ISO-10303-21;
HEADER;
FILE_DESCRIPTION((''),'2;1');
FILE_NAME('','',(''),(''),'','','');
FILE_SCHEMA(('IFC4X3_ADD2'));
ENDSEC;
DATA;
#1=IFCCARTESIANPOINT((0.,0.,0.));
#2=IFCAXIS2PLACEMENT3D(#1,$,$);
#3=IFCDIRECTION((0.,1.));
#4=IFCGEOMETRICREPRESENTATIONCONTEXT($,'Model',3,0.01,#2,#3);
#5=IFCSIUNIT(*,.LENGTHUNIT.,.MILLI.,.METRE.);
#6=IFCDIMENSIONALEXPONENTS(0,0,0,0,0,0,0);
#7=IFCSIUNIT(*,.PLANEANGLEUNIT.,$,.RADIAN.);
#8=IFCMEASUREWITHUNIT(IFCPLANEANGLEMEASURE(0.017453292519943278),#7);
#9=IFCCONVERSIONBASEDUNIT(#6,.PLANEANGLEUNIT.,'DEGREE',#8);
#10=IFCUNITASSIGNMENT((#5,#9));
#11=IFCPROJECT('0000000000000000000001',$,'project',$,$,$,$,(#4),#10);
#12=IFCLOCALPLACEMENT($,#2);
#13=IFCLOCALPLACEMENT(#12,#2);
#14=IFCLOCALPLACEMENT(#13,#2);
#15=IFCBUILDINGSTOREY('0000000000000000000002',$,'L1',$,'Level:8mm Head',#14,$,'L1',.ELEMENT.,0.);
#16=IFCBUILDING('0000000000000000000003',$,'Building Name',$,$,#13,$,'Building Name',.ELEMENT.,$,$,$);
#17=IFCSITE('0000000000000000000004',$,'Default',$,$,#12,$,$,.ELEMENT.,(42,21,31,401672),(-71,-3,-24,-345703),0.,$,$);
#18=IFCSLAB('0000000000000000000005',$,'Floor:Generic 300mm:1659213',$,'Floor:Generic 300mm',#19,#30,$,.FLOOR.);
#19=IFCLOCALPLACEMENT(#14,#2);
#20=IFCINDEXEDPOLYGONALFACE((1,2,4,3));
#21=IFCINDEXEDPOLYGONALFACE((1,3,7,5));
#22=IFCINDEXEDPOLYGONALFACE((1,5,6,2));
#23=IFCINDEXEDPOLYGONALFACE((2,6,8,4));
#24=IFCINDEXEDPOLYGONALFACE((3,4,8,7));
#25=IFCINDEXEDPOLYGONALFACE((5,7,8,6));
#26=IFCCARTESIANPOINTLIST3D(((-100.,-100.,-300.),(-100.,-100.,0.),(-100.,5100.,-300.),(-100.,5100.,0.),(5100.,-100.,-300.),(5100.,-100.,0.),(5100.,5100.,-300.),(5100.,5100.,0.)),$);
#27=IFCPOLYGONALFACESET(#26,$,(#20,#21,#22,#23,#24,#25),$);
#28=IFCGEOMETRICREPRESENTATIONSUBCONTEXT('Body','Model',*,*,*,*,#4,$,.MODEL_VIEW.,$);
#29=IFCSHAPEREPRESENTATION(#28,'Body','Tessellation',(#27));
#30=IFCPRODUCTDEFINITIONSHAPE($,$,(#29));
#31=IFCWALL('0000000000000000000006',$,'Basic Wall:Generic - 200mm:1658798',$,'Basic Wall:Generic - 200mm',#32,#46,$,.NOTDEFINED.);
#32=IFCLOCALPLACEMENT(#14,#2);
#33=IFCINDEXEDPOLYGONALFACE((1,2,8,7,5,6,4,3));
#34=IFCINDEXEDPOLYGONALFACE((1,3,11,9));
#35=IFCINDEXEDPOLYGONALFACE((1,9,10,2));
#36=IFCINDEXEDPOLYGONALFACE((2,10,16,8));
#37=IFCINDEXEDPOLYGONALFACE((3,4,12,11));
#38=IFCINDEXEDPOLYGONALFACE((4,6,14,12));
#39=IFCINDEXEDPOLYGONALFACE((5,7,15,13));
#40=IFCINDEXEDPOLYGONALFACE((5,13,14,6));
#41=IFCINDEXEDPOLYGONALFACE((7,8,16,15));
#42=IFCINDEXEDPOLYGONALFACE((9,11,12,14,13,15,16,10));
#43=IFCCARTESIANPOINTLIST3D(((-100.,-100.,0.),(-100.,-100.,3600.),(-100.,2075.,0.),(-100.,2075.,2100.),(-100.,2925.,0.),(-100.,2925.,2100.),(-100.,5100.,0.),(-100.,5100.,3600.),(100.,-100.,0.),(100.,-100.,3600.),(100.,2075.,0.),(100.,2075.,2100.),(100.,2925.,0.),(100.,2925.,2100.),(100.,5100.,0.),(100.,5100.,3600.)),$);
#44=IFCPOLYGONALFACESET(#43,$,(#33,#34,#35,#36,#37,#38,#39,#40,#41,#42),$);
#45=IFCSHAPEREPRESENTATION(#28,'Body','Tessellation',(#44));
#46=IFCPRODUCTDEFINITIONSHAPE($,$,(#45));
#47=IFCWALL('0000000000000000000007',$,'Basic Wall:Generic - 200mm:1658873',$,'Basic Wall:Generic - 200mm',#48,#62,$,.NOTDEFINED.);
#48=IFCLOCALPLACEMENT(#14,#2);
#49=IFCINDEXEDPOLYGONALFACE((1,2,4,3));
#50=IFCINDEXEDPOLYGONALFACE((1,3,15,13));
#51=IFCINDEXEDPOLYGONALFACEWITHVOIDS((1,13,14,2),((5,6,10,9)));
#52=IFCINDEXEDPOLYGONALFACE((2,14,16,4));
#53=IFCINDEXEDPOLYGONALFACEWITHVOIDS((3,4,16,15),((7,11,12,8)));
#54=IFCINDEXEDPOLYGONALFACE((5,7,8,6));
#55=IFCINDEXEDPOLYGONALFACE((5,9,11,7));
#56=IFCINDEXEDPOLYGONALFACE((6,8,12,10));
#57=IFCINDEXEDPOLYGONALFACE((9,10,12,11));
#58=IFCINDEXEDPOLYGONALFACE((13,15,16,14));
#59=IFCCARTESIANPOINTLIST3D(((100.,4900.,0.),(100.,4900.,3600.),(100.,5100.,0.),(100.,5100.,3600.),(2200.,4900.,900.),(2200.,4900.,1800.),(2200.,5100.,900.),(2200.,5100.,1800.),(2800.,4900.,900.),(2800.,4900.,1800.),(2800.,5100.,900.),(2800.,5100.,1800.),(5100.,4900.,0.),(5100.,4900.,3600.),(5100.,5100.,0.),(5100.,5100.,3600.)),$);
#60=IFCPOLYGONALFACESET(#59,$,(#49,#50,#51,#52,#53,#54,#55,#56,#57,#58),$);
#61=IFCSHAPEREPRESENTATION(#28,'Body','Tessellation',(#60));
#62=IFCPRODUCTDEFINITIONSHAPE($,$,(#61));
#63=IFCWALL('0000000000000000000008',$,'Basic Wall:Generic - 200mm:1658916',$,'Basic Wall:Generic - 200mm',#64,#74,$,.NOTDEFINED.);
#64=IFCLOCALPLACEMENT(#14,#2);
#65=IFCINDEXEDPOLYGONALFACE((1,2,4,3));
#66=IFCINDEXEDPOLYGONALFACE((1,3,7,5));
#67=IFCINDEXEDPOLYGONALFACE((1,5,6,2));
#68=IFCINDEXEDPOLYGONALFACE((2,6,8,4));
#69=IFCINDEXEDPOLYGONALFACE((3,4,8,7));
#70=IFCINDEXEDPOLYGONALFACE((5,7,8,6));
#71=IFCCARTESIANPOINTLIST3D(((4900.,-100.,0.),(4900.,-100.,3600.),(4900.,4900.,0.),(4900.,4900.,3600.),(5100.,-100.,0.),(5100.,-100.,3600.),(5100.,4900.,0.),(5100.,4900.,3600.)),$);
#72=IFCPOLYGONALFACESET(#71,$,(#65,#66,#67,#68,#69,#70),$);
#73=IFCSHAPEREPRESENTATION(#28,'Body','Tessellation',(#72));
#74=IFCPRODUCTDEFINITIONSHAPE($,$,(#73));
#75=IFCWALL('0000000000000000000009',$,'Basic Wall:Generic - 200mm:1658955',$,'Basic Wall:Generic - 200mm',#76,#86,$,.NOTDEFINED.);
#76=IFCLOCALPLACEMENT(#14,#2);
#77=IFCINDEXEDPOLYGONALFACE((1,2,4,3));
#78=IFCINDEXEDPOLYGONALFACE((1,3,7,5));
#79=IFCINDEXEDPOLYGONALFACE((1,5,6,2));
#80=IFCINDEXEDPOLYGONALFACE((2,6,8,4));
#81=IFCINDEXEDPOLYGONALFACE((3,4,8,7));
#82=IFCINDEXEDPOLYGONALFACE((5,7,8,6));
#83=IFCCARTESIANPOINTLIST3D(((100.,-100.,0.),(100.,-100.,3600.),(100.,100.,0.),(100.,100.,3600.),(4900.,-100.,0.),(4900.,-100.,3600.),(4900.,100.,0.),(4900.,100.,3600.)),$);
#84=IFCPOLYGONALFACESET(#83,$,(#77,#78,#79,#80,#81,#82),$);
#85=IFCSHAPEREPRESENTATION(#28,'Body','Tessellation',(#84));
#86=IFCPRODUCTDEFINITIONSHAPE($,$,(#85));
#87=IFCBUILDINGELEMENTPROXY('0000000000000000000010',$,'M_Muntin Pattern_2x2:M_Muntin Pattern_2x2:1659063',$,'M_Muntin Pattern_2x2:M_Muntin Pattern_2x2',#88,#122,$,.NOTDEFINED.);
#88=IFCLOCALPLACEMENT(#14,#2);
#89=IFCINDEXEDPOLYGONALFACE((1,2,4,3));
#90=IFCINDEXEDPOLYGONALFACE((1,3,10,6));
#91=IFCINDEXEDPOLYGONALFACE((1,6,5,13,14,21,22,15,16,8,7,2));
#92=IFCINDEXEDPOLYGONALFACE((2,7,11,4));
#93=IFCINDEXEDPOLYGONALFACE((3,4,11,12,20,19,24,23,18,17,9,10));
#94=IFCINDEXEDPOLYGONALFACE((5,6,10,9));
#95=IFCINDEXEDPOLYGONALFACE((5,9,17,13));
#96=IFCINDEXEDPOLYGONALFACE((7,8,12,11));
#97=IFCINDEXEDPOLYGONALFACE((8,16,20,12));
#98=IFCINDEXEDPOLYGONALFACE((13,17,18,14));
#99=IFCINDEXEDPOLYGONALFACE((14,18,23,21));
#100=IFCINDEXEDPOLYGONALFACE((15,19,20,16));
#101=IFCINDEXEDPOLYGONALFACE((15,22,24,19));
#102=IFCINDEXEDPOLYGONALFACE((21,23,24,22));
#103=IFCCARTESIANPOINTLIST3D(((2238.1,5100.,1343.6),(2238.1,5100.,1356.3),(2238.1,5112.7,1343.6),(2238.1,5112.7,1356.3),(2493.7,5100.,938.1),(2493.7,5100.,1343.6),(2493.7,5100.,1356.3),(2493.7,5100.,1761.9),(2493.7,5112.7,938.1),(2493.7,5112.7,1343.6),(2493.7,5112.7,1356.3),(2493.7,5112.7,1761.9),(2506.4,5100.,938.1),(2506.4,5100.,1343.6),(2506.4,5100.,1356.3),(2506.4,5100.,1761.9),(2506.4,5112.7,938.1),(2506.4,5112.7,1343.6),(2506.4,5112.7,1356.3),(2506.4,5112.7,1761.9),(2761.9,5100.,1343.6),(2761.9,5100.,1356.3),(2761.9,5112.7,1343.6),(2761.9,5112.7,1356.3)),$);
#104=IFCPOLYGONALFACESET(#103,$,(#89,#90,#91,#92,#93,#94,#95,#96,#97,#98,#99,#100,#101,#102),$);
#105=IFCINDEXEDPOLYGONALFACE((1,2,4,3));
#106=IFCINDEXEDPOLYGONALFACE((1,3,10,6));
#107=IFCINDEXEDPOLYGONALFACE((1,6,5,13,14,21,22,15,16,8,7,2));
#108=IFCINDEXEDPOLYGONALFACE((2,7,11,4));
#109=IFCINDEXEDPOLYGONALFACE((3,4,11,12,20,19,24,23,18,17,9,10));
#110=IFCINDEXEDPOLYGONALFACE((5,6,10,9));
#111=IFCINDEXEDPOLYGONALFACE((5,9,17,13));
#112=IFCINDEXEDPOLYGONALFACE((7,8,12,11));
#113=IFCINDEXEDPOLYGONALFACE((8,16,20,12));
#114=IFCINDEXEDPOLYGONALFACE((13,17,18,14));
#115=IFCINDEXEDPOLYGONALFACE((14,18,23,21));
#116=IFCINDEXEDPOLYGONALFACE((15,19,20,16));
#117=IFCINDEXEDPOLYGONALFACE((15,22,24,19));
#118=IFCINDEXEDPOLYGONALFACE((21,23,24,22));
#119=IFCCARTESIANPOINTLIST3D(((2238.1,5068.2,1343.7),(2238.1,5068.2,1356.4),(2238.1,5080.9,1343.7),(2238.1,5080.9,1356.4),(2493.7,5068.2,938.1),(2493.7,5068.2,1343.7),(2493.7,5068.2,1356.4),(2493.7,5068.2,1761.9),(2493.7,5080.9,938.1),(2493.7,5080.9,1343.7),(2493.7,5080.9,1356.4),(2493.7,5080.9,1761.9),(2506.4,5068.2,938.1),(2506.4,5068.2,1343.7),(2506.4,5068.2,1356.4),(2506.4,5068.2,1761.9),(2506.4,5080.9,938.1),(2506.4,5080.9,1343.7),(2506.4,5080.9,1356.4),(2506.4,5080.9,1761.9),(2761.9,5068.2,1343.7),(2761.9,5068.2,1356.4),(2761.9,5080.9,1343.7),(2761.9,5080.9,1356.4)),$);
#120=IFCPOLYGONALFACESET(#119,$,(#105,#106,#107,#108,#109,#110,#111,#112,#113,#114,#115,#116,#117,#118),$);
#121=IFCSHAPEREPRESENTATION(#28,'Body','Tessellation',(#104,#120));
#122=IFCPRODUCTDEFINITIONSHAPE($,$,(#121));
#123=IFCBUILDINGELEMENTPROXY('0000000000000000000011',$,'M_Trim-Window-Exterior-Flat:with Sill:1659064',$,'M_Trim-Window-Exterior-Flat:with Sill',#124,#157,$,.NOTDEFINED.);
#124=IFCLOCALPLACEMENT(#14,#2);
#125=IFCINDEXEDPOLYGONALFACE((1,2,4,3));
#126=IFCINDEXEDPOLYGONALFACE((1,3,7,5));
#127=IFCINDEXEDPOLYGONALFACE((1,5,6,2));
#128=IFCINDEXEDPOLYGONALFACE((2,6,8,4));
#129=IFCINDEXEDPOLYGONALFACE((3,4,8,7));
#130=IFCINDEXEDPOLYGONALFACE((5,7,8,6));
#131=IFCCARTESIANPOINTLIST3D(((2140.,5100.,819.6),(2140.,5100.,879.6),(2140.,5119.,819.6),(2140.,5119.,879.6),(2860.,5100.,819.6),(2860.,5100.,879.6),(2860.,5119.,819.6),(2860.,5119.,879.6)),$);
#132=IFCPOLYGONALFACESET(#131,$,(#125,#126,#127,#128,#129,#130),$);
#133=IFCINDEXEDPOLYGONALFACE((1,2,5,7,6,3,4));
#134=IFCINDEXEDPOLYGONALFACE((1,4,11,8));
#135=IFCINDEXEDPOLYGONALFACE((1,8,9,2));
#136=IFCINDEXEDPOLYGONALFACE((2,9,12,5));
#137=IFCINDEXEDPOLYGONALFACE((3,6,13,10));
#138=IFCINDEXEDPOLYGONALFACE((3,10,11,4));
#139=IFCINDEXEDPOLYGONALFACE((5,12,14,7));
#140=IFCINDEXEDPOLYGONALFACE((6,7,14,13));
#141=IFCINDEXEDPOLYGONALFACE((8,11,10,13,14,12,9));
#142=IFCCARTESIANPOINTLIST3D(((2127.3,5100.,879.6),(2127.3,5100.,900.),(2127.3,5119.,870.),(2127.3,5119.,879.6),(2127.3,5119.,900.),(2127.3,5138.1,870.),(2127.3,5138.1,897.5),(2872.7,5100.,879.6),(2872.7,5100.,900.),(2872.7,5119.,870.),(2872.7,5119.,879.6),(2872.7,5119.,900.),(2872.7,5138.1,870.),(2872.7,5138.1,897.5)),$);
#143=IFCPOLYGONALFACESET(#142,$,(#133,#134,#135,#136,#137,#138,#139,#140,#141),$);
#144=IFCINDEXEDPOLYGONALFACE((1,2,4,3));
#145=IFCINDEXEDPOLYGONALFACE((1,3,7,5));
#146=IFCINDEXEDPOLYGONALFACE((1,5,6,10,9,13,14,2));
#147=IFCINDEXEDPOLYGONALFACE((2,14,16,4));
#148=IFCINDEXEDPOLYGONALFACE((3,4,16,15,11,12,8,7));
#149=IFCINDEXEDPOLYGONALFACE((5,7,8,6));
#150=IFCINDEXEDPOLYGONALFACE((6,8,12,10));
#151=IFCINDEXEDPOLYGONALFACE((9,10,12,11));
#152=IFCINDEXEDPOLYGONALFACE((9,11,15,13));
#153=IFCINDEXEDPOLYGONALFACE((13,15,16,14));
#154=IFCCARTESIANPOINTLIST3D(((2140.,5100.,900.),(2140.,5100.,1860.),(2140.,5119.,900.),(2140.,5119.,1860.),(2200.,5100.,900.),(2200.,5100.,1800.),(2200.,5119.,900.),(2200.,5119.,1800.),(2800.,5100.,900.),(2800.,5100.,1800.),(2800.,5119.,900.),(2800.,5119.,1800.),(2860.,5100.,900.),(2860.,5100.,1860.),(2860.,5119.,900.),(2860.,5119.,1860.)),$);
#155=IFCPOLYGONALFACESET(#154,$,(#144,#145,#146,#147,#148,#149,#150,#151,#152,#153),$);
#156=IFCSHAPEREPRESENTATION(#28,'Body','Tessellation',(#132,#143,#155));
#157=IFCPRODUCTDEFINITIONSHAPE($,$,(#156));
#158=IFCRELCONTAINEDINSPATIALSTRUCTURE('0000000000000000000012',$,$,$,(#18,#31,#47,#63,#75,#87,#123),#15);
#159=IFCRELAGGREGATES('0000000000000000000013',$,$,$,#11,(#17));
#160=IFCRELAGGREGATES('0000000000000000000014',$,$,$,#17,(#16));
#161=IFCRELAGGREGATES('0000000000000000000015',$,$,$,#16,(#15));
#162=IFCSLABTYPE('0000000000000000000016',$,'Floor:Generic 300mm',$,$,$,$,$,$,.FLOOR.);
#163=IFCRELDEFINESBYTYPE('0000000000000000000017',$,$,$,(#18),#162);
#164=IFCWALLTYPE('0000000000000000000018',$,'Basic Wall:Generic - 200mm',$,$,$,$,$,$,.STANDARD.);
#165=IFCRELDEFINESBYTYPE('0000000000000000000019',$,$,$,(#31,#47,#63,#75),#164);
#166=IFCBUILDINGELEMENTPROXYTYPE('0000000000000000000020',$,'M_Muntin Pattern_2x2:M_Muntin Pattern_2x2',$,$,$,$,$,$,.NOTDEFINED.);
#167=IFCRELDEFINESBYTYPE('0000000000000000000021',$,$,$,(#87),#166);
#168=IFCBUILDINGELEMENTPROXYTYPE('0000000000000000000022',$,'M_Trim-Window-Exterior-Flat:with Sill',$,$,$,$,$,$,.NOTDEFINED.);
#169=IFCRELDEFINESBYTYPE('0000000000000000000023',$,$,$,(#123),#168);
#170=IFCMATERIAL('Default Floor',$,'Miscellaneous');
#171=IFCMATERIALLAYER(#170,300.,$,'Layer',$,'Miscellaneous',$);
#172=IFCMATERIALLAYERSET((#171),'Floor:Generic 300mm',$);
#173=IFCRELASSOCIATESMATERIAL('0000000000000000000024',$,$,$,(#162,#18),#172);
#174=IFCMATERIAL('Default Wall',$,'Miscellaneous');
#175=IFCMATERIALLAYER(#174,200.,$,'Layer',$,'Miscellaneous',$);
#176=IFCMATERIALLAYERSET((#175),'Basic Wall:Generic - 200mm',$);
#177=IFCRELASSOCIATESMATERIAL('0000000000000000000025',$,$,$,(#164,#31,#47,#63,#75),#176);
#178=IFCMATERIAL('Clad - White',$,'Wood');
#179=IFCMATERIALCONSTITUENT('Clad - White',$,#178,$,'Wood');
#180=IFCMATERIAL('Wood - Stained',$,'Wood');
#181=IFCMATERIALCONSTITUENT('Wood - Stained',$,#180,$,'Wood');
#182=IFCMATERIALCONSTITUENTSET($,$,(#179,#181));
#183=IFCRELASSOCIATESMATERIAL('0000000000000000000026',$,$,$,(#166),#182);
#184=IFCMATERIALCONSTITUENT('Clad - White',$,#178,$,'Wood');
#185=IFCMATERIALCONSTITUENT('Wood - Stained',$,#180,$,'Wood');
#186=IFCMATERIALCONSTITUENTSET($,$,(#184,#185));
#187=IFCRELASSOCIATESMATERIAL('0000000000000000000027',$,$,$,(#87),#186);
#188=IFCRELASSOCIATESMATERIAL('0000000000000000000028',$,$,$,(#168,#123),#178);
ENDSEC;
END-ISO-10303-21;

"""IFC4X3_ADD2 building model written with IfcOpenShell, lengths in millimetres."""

from ifc_helpers import new_model, entity, si_unit, converted_unit, direction, frame, frame_2d, origin, place, context, subcontext, project, spatial, polyline, rectangle, outline, extrude, source, transform, mapped, material, layer, layer_set, layer_usage, constituent, constituent_set, type_object, type_shapes, element, save


model = new_model("IFC4X3_ADD2")

# Units and contexts
model_context = context("Model", 3, precision=0.01, world=origin(), true_north=direction((0.0, 1.0)))
body_context = subcontext(model_context, "Body", "Model", "MODEL_VIEW")
ifc_project = project(units=[si_unit("LENGTHUNIT", "METRE", prefix="MILLI"), converted_unit("PLANEANGLEUNIT", "DEGREE", entity("IfcPlaneAngleMeasure", 0.017453292519943278), si_unit("PLANEANGLEUNIT", "RADIAN"), dimensions=[0, 0, 0, 0, 0, 0, 0])], contexts=[model_context])

# Site, building, storey
site_placement = place(None, origin())
site = spatial("IfcSite", under=ifc_project, at=site_placement, Name="Default", CompositionType="ELEMENT", RefLatitude=(42, 21, 31, 401672), RefLongitude=(-71, -3, -24, -345703), RefElevation=0.0)
building_placement = place(site_placement, origin())
building = spatial("IfcBuilding", under=site, at=building_placement, Name="Building Name", LongName="Building Name", CompositionType="ELEMENT")
storey_placement = place(building_placement, origin())
storey = spatial("IfcBuildingStorey", under=building, at=storey_placement, Name="L1", ObjectType="Level:8mm Head", LongName="L1", CompositionType="ELEMENT", Elevation=0.0)

# Slab
ifc_material_1 = material(Name="Default Floor", Category="Miscellaneous")
ifc_layer_1 = layer(ifc_material_1, 300.0, Name="Layer", Category="Miscellaneous")
ifc_layer_set_1 = layer_set([ifc_layer_1], Name="Floor:Generic 300mm")
ifc_layer_usage = layer_usage(ifc_layer_set_1, "AXIS3", "POSITIVE", 0.0)
slab_type = type_object("IfcSlabType", Name="Floor:Generic 300mm", PredefinedType="FLOOR", material=ifc_layer_set_1)
slab_placement = place(storey_placement, origin())
element("IfcSlab", 1, at=slab_placement, inside=storey, type_object=slab_type, material=ifc_layer_usage, Name="Floor:Generic 300mm:1659213", ObjectType="Floor:Generic 300mm", PredefinedType="FLOOR", context=body_context, shape_type="SweptSolid", body=[
    extrude(rectangle(XDim=5200.0, YDim=5200.0, at=frame_2d((0.0, 0.0), x_axis=(1.0, 0.0))), frame((2500.0, 2500.0, 0.0), z_axis=(0.0, 0.0, -1.0), x_axis=(0.0, 1.0, 0.0)), (0.0, 0.0, 1.0), 300.0),
])

# Walls, openings
ifc_material_2 = material(Name="Default Wall", Category="Miscellaneous")
ifc_layer_2 = layer(ifc_material_2, 200.0, Name="Layer", Category="Miscellaneous")
ifc_layer_set_2 = layer_set([ifc_layer_2], Name="Basic Wall:Generic - 200mm")
wall_type = type_object("IfcWallType", Name="Basic Wall:Generic - 200mm", PredefinedType="STANDARD", material=ifc_layer_set_2)
wall_1_placement = place(storey_placement, frame((0.0, -100.0, 0.0), z_axis=(0.0, 0.0, 1.0), x_axis=(0.0, 1.0, 0.0)))
wall_1 = element("IfcWall", 2, at=wall_1_placement, inside=storey, type_object=wall_type, material=ifc_layer_set_2, Name="Basic Wall:Generic - 200mm:1658798", ObjectType="Basic Wall:Generic - 200mm", PredefinedType="NOTDEFINED", context=body_context, shape_type="SweptSolid", body=[
    extrude(rectangle(XDim=5200.0, YDim=200.0, at=frame_2d((2600.0, 0.0), x_axis=(1.0, 0.0))), origin(), (0.0, 0.0, 1.0), 3600.0),
])
opening_1_placement = place(wall_1_placement, frame((2175.0, -100.0, 0.0)))
element("IfcOpeningElement", 3, at=opening_1_placement, cuts=wall_1, PredefinedType="OPENING", context=body_context, shape_type="SweptSolid", body=[
    extrude(rectangle(XDim=2100.0, YDim=850.0, at=frame_2d((1050.0, 425.0), x_axis=(1.0, 0.0))), frame((0.0, 0.0, 0.0), z_axis=(0.0, 1.0, 0.0), x_axis=(0.0, 0.0, 1.0)), (0.0, 0.0, 1.0), 200.0),
])
wall_2_placement = place(storey_placement, frame((100.0, 5000.0, 0.0)))
wall_2 = element("IfcWall", 4, at=wall_2_placement, inside=storey, type_object=wall_type, material=ifc_layer_set_2, Name="Basic Wall:Generic - 200mm:1658873", ObjectType="Basic Wall:Generic - 200mm", PredefinedType="NOTDEFINED", context=body_context, shape_type="SweptSolid", body=[
    extrude(rectangle(XDim=5000.0, YDim=200.0, at=frame_2d((2500.0, 0.0), x_axis=(-1.0, 0.0))), origin(), (0.0, 0.0, 1.0), 3600.0),
])
opening_2_placement = place(wall_2_placement, frame((2100.0, -100.0, 900.0)))
element("IfcOpeningElement", 5, at=opening_2_placement, cuts=wall_2, PredefinedType="OPENING", context=body_context, shape_type="SweptSolid", body=[
    extrude(rectangle(XDim=900.0, YDim=600.0, at=frame_2d((450.0, 300.0), x_axis=(-1.0, 0.0))), frame((0.0, 0.0, 0.0), z_axis=(0.0, 1.0, 0.0), x_axis=(0.0, 0.0, 1.0)), (0.0, 0.0, 1.0), 200.0),
])

# Walls
wall_3_placement = place(storey_placement, frame((5000.0, 4900.0, 0.0), z_axis=(0.0, 0.0, 1.0), x_axis=(0.0, -1.0, 0.0)))
element("IfcWall", 6, at=wall_3_placement, inside=storey, type_object=wall_type, material=ifc_layer_set_2, Name="Basic Wall:Generic - 200mm:1658916", ObjectType="Basic Wall:Generic - 200mm", PredefinedType="NOTDEFINED", context=body_context, shape_type="SweptSolid", body=[
    extrude(rectangle(XDim=5000.0, YDim=200.0, at=frame_2d((2500.0, 0.0), x_axis=(-1.0, 0.0))), origin(), (0.0, 0.0, 1.0), 3600.0),
])
wall_4_placement = place(storey_placement, frame((4900.0, 0.0, 0.0), z_axis=(0.0, 0.0, 1.0), x_axis=(-1.0, 0.0, 0.0)))
element("IfcWall", 7, at=wall_4_placement, inside=storey, type_object=wall_type, material=ifc_layer_set_2, Name="Basic Wall:Generic - 200mm:1658955", ObjectType="Basic Wall:Generic - 200mm", PredefinedType="NOTDEFINED", context=body_context, shape_type="SweptSolid", body=[
    extrude(rectangle(XDim=4800.0, YDim=200.0, at=frame_2d((2400.0, 0.0), x_axis=(-1.0, 0.0))), origin(), (0.0, 0.0, 1.0), 3600.0),
])

# Building element proxies
ifc_material_3 = material(Name="Clad - White", Category="Wood")
ifc_constituent_1 = constituent(ifc_material_3, Name="Clad - White", Category="Wood")
ifc_material_4 = material(Name="Wood - Stained", Category="Wood")
ifc_constituent_2 = constituent(ifc_material_4, Name="Wood - Stained", Category="Wood")
ifc_constituent_set_1 = constituent_set(constituents=[ifc_constituent_1, ifc_constituent_2])
ifc_constituent_3 = constituent(ifc_material_3, Name="Clad - White", Category="Wood")
ifc_constituent_4 = constituent(ifc_material_4, Name="Wood - Stained", Category="Wood")
ifc_constituent_set_2 = constituent_set(constituents=[ifc_constituent_3, ifc_constituent_4])
building_element_proxy_type_1 = type_object("IfcBuildingElementProxyType", Name="M_Muntin Pattern_2x2:M_Muntin Pattern_2x2", PredefinedType="NOTDEFINED", material=ifc_constituent_set_2)
shared_shape_1 = source(origin(), body_context, "Body", "SweptSolid", [
    extrude(outline(polyline([(6.4, -6.4), (411.9, -6.4), (411.9, 6.3), (6.4, 6.3), (6.4, 261.9), (-6.3, 261.9), (-6.3, 6.3), (-411.9, 6.3), (-411.9, -6.4), (-6.3, -6.4), (-6.3, -261.9), (6.4, -261.9), (6.4, -6.4)])), frame((0.0, -22.2, 411.9), z_axis=(0.0, 1.0, 0.0), x_axis=(0.0, 0.0, 1.0)), (0.0, 0.0, 1.0), 12.7),
    extrude(outline(polyline([(6.4, -6.4), (411.9, -6.4), (411.9, 6.3), (6.4, 6.3), (6.4, 261.9), (-6.3, 261.9), (-6.3, 6.3), (-411.9, 6.3), (-411.9, -6.4), (-6.3, -6.4), (-6.3, -261.9), (6.4, -261.9), (6.4, -6.4)])), frame((0.0, 9.5, 411.9), z_axis=(0.0, 1.0, 0.0), x_axis=(0.0, 0.0, 1.0)), (0.0, 0.0, 1.0), 12.7),
])
type_shapes(building_element_proxy_type_1, [shared_shape_1])
proxy_1_placement = place(storey_placement, frame((2500.0, 5090.5, 938.1), z_axis=(0.0, 0.0, 1.0), x_axis=(-1.0, 0.0, 0.0)))
element("IfcBuildingElementProxy", 8, at=proxy_1_placement, inside=storey, type_object=building_element_proxy_type_1, material=ifc_constituent_set_1, Name="M_Muntin Pattern_2x2:M_Muntin Pattern_2x2:1659063", ObjectType="M_Muntin Pattern_2x2:M_Muntin Pattern_2x2", PredefinedType="NOTDEFINED", context=body_context, shape_type="MappedRepresentation", body=[
    mapped(shared_shape_1, transform((0.0, 0.0, 0.0), scale=1.0)),
])
building_element_proxy_type_2 = type_object("IfcBuildingElementProxyType", Name="M_Trim-Window-Exterior-Flat:with Sill", PredefinedType="NOTDEFINED", material=ifc_material_3)
shared_shape_2 = source(origin(), body_context, "Body", "SweptSolid", [
    extrude(rectangle(XDim=720.0, YDim=60.0, at=frame_2d((0.0, 0.0), x_axis=(1.0, 0.0))), frame((0.0, -950.4, 0.0), z_axis=(0.0, 0.0, 1.0), x_axis=(-1.0, 0.0, 0.0)), (0.0, 0.0, 1.0), 19.0),
    extrude(outline(polyline([(-19.0, -15.2), (0.0, -15.2), (0.0, -5.7), (19.0, -5.7), (19.0, 14.8), (0.0, 14.8), (-19.0, 12.3), (-19.0, -15.2)])), frame((-372.7, -914.8, 19.0), z_axis=(1.0, 0.0, 0.0), x_axis=(0.0, 0.0, -1.0)), (0.0, 0.0, 1.0), 745.4),
    extrude(outline(polyline([(-495.0, -360.0), (465.0, -360.0), (465.0, -300.0), (-435.0, -300.0), (-435.0, 300.0), (465.0, 300.0), (465.0, 360.0), (-495.0, 360.0), (-495.0, -360.0)])), frame((0.0, -435.0, 0.0), z_axis=(0.0, 0.0, 1.0), x_axis=(0.0, -1.0, 0.0)), (0.0, 0.0, 1.0), 19.0),
])
type_shapes(building_element_proxy_type_2, [shared_shape_2])
proxy_2_placement = place(storey_placement, frame((2500.0, 5100.0, 1800.0), z_axis=(0.0, 1.0, 0.0), x_axis=(-1.0, 0.0, 0.0)))
element("IfcBuildingElementProxy", 9, at=proxy_2_placement, inside=storey, type_object=building_element_proxy_type_2, material=ifc_material_3, Name="M_Trim-Window-Exterior-Flat:with Sill:1659064", ObjectType="M_Trim-Window-Exterior-Flat:with Sill", PredefinedType="NOTDEFINED", context=body_context, shape_type="MappedRepresentation", body=[
    mapped(shared_shape_2, transform((0.0, 0.0, 0.0), scale=1.0)),
])

save(model, "model.ifc")
